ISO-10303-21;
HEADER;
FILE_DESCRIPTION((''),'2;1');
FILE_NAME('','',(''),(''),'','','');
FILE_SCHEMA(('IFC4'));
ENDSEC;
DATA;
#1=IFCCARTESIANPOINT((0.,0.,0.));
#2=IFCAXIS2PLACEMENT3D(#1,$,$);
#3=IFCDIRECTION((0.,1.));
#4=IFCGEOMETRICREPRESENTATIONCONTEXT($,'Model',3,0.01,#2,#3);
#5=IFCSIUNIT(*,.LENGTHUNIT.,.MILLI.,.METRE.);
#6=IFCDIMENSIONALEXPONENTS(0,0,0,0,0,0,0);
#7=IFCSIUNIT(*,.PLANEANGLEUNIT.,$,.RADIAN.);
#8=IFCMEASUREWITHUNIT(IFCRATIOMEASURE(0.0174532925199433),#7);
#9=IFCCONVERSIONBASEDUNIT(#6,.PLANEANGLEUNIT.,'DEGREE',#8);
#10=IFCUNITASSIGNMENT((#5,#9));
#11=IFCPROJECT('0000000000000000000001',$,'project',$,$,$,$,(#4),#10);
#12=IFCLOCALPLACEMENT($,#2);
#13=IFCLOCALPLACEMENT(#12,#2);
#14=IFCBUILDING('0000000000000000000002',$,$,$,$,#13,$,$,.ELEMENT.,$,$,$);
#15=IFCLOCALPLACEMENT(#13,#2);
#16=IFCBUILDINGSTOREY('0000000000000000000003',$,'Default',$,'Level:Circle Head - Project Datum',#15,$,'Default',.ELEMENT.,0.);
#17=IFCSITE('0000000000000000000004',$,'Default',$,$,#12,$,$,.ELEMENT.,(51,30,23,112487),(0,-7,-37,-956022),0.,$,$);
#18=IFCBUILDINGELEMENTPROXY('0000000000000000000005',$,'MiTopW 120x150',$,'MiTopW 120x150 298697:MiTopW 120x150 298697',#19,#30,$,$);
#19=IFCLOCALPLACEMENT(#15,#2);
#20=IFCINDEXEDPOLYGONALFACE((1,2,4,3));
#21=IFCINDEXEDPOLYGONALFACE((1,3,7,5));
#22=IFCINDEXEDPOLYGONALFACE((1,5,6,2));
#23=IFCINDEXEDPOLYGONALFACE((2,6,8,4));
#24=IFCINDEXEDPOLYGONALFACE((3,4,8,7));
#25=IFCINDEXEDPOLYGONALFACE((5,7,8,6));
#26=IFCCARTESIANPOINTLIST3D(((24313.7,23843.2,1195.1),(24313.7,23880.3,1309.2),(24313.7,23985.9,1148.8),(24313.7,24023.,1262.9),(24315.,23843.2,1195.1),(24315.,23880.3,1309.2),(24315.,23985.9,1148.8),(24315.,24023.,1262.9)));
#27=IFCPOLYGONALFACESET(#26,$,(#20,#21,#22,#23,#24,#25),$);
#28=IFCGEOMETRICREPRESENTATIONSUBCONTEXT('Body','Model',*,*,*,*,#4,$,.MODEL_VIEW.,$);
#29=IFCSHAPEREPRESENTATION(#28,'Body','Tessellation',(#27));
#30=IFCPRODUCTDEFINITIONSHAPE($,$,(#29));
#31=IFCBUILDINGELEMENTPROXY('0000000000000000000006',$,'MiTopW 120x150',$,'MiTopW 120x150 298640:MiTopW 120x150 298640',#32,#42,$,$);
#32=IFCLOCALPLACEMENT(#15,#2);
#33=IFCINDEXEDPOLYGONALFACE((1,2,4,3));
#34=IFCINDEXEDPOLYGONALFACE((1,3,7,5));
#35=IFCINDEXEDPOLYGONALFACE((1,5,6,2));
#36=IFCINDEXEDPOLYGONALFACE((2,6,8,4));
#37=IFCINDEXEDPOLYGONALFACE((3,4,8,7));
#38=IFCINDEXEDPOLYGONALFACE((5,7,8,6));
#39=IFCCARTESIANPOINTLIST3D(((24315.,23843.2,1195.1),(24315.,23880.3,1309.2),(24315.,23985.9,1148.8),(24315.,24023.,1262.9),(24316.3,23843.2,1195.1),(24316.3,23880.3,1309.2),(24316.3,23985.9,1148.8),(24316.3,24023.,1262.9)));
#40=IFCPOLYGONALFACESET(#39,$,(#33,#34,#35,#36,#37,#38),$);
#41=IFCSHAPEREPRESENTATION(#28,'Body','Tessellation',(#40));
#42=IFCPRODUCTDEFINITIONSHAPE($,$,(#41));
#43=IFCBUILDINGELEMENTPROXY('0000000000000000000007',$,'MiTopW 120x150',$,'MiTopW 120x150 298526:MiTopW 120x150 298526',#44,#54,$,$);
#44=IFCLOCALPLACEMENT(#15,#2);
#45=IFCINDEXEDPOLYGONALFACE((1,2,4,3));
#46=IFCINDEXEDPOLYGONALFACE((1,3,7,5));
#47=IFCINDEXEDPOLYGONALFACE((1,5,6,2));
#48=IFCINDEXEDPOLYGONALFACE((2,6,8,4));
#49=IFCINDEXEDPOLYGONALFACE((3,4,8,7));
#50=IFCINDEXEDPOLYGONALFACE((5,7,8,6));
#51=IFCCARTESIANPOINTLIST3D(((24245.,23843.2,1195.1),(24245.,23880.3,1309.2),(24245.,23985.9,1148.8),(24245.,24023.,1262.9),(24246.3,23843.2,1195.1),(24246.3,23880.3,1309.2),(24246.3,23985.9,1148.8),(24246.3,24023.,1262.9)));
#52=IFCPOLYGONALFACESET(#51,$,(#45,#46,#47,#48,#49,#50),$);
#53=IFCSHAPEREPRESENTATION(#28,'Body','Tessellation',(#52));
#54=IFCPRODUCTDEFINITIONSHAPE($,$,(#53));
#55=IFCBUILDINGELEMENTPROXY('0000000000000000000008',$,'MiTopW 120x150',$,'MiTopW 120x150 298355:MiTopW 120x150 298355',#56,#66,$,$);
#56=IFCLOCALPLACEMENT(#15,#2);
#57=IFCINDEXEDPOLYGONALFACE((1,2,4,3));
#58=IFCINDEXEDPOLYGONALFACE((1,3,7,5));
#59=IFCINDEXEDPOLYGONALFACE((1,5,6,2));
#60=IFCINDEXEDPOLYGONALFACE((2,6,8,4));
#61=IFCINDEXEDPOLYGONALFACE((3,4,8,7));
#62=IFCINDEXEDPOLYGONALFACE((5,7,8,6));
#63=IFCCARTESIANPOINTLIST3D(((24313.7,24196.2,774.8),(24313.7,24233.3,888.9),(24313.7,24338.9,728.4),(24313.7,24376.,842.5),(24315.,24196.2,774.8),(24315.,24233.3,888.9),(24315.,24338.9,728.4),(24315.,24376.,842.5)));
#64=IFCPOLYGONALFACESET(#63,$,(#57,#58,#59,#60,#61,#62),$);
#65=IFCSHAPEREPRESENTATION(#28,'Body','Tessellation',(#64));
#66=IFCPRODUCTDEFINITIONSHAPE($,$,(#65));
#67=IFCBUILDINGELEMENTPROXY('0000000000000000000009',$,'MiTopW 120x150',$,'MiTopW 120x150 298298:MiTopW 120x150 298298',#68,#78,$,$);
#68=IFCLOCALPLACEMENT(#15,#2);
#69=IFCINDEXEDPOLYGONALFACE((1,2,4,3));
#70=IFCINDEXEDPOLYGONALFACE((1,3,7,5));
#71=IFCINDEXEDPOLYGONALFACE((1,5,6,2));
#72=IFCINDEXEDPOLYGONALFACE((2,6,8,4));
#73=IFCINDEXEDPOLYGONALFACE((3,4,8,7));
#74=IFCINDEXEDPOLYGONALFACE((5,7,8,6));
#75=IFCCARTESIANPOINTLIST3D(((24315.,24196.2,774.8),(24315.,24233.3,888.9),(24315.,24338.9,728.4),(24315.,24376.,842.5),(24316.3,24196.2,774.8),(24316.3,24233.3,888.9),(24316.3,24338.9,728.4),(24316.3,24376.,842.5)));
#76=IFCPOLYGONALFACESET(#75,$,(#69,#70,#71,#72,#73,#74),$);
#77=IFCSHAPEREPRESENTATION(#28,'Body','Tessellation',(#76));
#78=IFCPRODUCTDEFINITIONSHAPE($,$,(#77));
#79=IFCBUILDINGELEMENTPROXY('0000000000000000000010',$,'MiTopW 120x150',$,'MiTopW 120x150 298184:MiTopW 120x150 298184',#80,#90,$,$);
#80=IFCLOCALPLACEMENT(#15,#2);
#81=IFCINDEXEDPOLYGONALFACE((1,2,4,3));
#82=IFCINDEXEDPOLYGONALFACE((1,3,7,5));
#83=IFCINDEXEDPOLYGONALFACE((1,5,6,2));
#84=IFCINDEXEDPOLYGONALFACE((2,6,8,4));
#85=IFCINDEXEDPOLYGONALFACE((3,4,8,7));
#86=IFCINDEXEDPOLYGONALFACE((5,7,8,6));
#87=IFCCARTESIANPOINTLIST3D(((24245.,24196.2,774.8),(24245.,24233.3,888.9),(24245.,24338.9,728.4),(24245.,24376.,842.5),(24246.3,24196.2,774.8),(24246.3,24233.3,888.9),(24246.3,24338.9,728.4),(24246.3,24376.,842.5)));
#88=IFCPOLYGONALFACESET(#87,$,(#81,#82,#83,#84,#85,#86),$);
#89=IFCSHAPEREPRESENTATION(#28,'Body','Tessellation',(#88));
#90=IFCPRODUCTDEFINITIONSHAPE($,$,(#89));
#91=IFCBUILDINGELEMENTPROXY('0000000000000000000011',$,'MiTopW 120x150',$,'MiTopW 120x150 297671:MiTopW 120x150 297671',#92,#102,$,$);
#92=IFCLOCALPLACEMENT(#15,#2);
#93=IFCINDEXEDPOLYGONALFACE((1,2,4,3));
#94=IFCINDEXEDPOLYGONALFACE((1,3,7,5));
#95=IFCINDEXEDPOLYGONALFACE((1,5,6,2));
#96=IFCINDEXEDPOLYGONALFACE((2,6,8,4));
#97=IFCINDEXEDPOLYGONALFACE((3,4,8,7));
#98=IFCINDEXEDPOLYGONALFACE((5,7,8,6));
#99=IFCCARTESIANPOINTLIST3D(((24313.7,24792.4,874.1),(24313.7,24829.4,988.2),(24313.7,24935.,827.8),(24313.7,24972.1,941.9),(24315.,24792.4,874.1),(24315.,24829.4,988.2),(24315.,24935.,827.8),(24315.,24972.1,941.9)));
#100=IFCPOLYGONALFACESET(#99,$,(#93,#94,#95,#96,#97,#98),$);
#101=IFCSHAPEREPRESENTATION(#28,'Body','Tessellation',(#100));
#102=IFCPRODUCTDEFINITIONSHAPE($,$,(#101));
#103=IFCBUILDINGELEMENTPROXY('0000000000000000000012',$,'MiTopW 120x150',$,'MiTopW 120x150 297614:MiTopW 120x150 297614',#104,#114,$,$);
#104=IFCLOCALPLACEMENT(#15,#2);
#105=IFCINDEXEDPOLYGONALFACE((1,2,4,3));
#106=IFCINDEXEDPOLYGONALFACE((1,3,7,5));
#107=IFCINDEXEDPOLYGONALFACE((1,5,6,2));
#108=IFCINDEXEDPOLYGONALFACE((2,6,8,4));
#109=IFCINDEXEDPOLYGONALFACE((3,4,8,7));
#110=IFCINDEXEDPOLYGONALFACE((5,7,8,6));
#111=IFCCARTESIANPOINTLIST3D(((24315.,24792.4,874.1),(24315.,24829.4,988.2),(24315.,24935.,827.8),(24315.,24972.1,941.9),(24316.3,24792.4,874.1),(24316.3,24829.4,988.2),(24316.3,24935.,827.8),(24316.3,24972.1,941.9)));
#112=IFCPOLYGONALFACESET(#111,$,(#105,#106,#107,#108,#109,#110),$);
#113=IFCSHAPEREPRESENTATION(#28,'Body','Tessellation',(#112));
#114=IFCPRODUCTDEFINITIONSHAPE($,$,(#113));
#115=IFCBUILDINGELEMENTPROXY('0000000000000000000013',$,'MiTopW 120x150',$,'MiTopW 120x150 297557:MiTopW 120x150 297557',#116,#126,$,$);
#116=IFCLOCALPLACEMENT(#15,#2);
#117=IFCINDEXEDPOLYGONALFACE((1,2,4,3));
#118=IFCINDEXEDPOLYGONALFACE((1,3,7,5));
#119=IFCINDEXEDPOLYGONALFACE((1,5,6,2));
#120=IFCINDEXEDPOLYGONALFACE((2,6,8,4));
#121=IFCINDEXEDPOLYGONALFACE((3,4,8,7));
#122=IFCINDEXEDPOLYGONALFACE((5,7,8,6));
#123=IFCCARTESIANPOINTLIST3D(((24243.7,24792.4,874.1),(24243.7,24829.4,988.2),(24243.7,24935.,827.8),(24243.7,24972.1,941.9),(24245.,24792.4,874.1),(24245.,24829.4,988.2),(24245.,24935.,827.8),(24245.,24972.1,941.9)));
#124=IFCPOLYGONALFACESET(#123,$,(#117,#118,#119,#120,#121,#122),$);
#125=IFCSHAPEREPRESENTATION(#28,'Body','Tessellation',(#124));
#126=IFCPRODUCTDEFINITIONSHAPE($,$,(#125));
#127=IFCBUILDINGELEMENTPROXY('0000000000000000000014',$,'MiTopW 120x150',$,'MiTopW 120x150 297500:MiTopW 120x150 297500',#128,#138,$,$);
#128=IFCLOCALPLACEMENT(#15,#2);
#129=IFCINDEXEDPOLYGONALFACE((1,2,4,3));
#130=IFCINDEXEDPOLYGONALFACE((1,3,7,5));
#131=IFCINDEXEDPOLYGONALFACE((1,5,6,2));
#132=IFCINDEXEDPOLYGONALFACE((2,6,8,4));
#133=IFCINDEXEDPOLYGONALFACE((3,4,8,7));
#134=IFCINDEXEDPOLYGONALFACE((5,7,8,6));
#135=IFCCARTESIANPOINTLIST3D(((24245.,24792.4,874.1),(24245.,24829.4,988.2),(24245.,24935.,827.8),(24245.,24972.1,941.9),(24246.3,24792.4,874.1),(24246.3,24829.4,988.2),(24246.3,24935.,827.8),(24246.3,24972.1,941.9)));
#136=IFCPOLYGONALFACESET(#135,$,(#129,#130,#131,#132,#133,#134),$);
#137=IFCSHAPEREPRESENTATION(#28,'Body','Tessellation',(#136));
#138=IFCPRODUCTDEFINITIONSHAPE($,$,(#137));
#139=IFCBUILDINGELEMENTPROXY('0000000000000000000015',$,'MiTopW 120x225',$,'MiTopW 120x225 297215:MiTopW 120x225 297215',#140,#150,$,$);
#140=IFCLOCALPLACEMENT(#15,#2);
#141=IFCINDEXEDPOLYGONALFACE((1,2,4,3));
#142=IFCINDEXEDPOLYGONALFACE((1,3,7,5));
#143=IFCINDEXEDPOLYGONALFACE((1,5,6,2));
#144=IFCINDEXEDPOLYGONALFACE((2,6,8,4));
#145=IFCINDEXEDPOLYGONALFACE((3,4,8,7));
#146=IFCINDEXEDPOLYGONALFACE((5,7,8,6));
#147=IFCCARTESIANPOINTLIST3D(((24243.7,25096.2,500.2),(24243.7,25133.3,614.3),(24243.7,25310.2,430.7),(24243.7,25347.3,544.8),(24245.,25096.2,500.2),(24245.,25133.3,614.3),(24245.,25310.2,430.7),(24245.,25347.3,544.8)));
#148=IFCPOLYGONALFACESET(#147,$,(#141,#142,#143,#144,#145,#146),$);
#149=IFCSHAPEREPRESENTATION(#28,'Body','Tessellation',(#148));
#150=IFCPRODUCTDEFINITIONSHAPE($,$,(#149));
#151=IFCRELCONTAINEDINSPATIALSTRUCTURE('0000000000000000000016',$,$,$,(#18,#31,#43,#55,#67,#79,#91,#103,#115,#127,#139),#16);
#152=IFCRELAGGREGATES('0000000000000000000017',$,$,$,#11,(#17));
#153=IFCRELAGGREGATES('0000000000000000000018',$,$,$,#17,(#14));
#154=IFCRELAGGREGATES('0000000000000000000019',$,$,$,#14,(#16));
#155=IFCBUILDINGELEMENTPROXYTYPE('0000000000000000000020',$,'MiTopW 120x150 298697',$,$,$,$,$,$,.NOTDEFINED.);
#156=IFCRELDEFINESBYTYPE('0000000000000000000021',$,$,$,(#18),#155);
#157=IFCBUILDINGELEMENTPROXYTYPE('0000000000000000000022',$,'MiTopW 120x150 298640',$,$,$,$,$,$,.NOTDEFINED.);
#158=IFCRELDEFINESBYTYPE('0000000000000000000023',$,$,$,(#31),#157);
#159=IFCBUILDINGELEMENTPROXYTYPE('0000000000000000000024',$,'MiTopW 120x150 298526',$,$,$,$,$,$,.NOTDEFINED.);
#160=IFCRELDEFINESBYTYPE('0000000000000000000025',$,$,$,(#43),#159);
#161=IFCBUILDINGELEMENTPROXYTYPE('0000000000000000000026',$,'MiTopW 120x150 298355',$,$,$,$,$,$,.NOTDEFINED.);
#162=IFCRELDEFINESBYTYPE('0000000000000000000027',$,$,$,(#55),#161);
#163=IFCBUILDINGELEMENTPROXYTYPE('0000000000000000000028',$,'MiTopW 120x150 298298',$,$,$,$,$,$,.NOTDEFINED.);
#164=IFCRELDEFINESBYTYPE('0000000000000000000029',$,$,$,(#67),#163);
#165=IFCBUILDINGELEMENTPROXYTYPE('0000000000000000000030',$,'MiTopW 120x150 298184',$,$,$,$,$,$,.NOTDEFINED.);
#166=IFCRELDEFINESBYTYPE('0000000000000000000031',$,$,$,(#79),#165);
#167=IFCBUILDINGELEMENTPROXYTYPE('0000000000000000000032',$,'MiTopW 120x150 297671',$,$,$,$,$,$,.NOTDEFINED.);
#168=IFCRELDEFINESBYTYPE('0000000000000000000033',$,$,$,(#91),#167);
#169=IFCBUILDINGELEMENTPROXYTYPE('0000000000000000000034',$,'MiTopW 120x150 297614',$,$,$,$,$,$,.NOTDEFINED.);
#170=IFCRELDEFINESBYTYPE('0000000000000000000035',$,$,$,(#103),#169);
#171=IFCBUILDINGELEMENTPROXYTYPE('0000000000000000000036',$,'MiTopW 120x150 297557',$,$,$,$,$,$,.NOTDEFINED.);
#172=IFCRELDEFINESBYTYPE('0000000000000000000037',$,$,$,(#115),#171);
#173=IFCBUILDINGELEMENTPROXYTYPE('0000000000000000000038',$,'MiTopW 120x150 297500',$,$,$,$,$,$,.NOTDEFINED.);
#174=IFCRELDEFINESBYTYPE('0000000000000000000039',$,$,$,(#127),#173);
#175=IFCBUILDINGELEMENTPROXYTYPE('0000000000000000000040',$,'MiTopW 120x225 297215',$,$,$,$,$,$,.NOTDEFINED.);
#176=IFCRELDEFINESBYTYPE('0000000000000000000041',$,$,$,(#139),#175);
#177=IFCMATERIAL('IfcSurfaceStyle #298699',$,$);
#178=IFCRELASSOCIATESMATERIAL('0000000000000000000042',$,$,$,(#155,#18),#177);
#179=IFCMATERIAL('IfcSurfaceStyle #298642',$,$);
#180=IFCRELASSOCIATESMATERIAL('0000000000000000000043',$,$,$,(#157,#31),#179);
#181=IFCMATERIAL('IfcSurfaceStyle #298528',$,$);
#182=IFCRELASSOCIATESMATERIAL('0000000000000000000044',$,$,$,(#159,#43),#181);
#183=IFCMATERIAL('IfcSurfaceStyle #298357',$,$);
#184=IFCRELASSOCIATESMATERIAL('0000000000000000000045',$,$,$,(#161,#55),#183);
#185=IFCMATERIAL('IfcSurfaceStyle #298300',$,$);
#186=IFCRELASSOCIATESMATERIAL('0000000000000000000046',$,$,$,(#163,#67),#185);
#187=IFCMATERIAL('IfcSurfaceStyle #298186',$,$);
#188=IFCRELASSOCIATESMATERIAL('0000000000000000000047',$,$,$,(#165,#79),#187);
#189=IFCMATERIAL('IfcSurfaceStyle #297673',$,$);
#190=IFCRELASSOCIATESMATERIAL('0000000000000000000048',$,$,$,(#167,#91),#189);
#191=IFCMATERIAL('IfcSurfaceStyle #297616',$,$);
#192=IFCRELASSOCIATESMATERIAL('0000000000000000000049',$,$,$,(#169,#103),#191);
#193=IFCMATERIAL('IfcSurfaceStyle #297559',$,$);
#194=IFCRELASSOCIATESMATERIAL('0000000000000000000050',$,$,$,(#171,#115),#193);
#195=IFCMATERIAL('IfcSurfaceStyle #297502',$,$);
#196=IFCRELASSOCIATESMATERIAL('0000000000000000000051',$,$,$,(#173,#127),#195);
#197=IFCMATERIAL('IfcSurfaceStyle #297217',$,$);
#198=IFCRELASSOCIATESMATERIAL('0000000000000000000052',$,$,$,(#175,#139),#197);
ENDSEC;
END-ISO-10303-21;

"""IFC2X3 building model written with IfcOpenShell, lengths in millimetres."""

from ifc_helpers import new_model, entity, si_unit, converted_unit, direction, frame, origin, place, context, subcontext, project, spatial, polyline, outline, extrude, source, transform, mapped, material, type_object, type_shapes, element, save


model = new_model("IFC2X3")

# Units and contexts
model_context = context("Model", 3, precision=0.01, world=origin(), true_north=direction((0.0, 1.0)))
body_context = subcontext(model_context, "Body", "Model", "MODEL_VIEW")
ifc_project = project(units=[si_unit("LENGTHUNIT", "METRE", prefix="MILLI"), converted_unit("PLANEANGLEUNIT", "DEGREE", entity("IfcRatioMeasure", 0.0174532925199433), si_unit("PLANEANGLEUNIT", "RADIAN"), dimensions=[0, 0, 0, 0, 0, 0, 0])], contexts=[model_context])

# Site, building, storey
site_placement = place(None, origin())
site = spatial("IfcSite", under=ifc_project, at=site_placement, Name="Default", CompositionType="ELEMENT", RefLatitude=(51, 30, 23, 112487), RefLongitude=(0, -7, -37, -956022), RefElevation=0.0)
building_placement = place(site_placement, origin())
building = spatial("IfcBuilding", under=site, at=building_placement, CompositionType="ELEMENT")
storey_placement = place(building_placement, origin())
storey = spatial("IfcBuildingStorey", under=building, at=storey_placement, Name="Default", ObjectType="Level:Circle Head - Project Datum", LongName="Default", CompositionType="ELEMENT", Elevation=0.0)

# Building element proxies
ifc_material_1 = material(Name="IfcSurfaceStyle #298699")
building_element_proxy_type_1 = type_object("IfcBuildingElementProxyType", Name="MiTopW 120x150 298697", PredefinedType="NOTDEFINED", material=ifc_material_1)
shared_shape_1 = source(origin(), body_context, "Body", "SweptSolid", [
    extrude(outline(polyline([(-75.0, -60.0), (75.0, -60.0), (75.0, 60.0), (-75.0, 60.0), (-75.0, -60.0)])), frame((75.0, 60.0, 0.0), z_axis=(0.0, 0.0, 1.0), x_axis=(-1.0, 0.0, 0.0)), (0.0, 0.0, 1.0), 1.3),
])
type_shapes(building_element_proxy_type_1, [shared_shape_1])
proxy_1_placement = place(building_placement, frame((24315.0, 23985.9, 1148.8), z_axis=(-1.0, 0.0, 0.0), x_axis=(0.0, -0.951057, 0.309017)))
element("IfcBuildingElementProxy", 1, at=proxy_1_placement, inside=storey, type_object=building_element_proxy_type_1, material=ifc_material_1, Name="MiTopW 120x150", ObjectType="MiTopW 120x150 298697:MiTopW 120x150 298697", context=body_context, shape_type="MappedRepresentation", body=[
    mapped(shared_shape_1, transform((0.0, 0.0, 0.0), scale=1.0)),
])
ifc_material_2 = material(Name="IfcSurfaceStyle #298642")
building_element_proxy_type_2 = type_object("IfcBuildingElementProxyType", Name="MiTopW 120x150 298640", PredefinedType="NOTDEFINED", material=ifc_material_2)
shared_shape_2 = source(origin(), body_context, "Body", "SweptSolid", [
    extrude(outline(polyline([(-75.0, -60.0), (75.0, -60.0), (75.0, 60.0), (-75.0, 60.0), (-75.0, -60.0)])), frame((75.0, 60.0, 0.0), z_axis=(0.0, 0.0, 1.0), x_axis=(-1.0, 0.0, 0.0)), (0.0, 0.0, 1.0), 1.3),
])
type_shapes(building_element_proxy_type_2, [shared_shape_2])
proxy_2_placement = place(building_placement, frame((24316.3, 23985.9, 1148.8), z_axis=(-1.0, 0.0, 0.0), x_axis=(0.0, -0.951057, 0.309017)))
element("IfcBuildingElementProxy", 2, at=proxy_2_placement, inside=storey, type_object=building_element_proxy_type_2, material=ifc_material_2, Name="MiTopW 120x150", ObjectType="MiTopW 120x150 298640:MiTopW 120x150 298640", context=body_context, shape_type="MappedRepresentation", body=[
    mapped(shared_shape_2, transform((0.0, 0.0, 0.0), scale=1.0)),
])
ifc_material_3 = material(Name="IfcSurfaceStyle #298528")
building_element_proxy_type_3 = type_object("IfcBuildingElementProxyType", Name="MiTopW 120x150 298526", PredefinedType="NOTDEFINED", material=ifc_material_3)
shared_shape_3 = source(origin(), body_context, "Body", "SweptSolid", [
    extrude(outline(polyline([(-75.0, -60.0), (75.0, -60.0), (75.0, 60.0), (-75.0, 60.0), (-75.0, -60.0)])), frame((75.0, 60.0, 0.0), z_axis=(0.0, 0.0, 1.0), x_axis=(-1.0, 0.0, 0.0)), (0.0, 0.0, 1.0), 1.3),
])
type_shapes(building_element_proxy_type_3, [shared_shape_3])
proxy_3_placement = place(building_placement, frame((24246.3, 23985.9, 1148.8), z_axis=(-1.0, 0.0, 0.0), x_axis=(0.0, -0.951057, 0.309017)))
element("IfcBuildingElementProxy", 3, at=proxy_3_placement, inside=storey, type_object=building_element_proxy_type_3, material=ifc_material_3, Name="MiTopW 120x150", ObjectType="MiTopW 120x150 298526:MiTopW 120x150 298526", context=body_context, shape_type="MappedRepresentation", body=[
    mapped(shared_shape_3, transform((0.0, 0.0, 0.0), scale=1.0)),
])
ifc_material_4 = material(Name="IfcSurfaceStyle #298357")
building_element_proxy_type_4 = type_object("IfcBuildingElementProxyType", Name="MiTopW 120x150 298355", PredefinedType="NOTDEFINED", material=ifc_material_4)
shared_shape_4 = source(origin(), body_context, "Body", "SweptSolid", [
    extrude(outline(polyline([(-75.0, -60.0), (75.0, -60.0), (75.0, 60.0), (-75.0, 60.0), (-75.0, -60.0)])), frame((75.0, 60.0, 0.0), z_axis=(0.0, 0.0, 1.0), x_axis=(-1.0, 0.0, 0.0)), (0.0, 0.0, 1.0), 1.3),
])
type_shapes(building_element_proxy_type_4, [shared_shape_4])
proxy_4_placement = place(building_placement, frame((24315.0, 24338.9, 728.4), z_axis=(-1.0, 0.0, 0.0), x_axis=(0.0, -0.951057, 0.309017)))
element("IfcBuildingElementProxy", 4, at=proxy_4_placement, inside=storey, type_object=building_element_proxy_type_4, material=ifc_material_4, Name="MiTopW 120x150", ObjectType="MiTopW 120x150 298355:MiTopW 120x150 298355", context=body_context, shape_type="MappedRepresentation", body=[
    mapped(shared_shape_4, transform((0.0, 0.0, 0.0), scale=1.0)),
])
ifc_material_5 = material(Name="IfcSurfaceStyle #298300")
building_element_proxy_type_5 = type_object("IfcBuildingElementProxyType", Name="MiTopW 120x150 298298", PredefinedType="NOTDEFINED", material=ifc_material_5)
shared_shape_5 = source(origin(), body_context, "Body", "SweptSolid", [
    extrude(outline(polyline([(-75.0, -60.0), (75.0, -60.0), (75.0, 60.0), (-75.0, 60.0), (-75.0, -60.0)])), frame((75.0, 60.0, 0.0), z_axis=(0.0, 0.0, 1.0), x_axis=(-1.0, 0.0, 0.0)), (0.0, 0.0, 1.0), 1.3),
])
type_shapes(building_element_proxy_type_5, [shared_shape_5])
proxy_5_placement = place(building_placement, frame((24316.3, 24338.9, 728.4), z_axis=(-1.0, 0.0, 0.0), x_axis=(0.0, -0.951057, 0.309017)))
element("IfcBuildingElementProxy", 5, at=proxy_5_placement, inside=storey, type_object=building_element_proxy_type_5, material=ifc_material_5, Name="MiTopW 120x150", ObjectType="MiTopW 120x150 298298:MiTopW 120x150 298298", context=body_context, shape_type="MappedRepresentation", body=[
    mapped(shared_shape_5, transform((0.0, 0.0, 0.0), scale=1.0)),
])
ifc_material_6 = material(Name="IfcSurfaceStyle #298186")
building_element_proxy_type_6 = type_object("IfcBuildingElementProxyType", Name="MiTopW 120x150 298184", PredefinedType="NOTDEFINED", material=ifc_material_6)
shared_shape_6 = source(origin(), body_context, "Body", "SweptSolid", [
    extrude(outline(polyline([(-75.0, -60.0), (75.0, -60.0), (75.0, 60.0), (-75.0, 60.0), (-75.0, -60.0)])), frame((75.0, 60.0, 0.0), z_axis=(0.0, 0.0, 1.0), x_axis=(-1.0, 0.0, 0.0)), (0.0, 0.0, 1.0), 1.3),
])
type_shapes(building_element_proxy_type_6, [shared_shape_6])
proxy_6_placement = place(building_placement, frame((24246.3, 24338.9, 728.4), z_axis=(-1.0, 0.0, 0.0), x_axis=(0.0, -0.951057, 0.309017)))
element("IfcBuildingElementProxy", 6, at=proxy_6_placement, inside=storey, type_object=building_element_proxy_type_6, material=ifc_material_6, Name="MiTopW 120x150", ObjectType="MiTopW 120x150 298184:MiTopW 120x150 298184", context=body_context, shape_type="MappedRepresentation", body=[
    mapped(shared_shape_6, transform((0.0, 0.0, 0.0), scale=1.0)),
])
ifc_material_7 = material(Name="IfcSurfaceStyle #297673")
building_element_proxy_type_7 = type_object("IfcBuildingElementProxyType", Name="MiTopW 120x150 297671", PredefinedType="NOTDEFINED", material=ifc_material_7)
shared_shape_7 = source(origin(), body_context, "Body", "SweptSolid", [
    extrude(outline(polyline([(-75.0, -60.0), (75.0, -60.0), (75.0, 60.0), (-75.0, 60.0), (-75.0, -60.0)])), frame((75.0, 60.0, 0.0), z_axis=(0.0, 0.0, 1.0), x_axis=(-1.0, 0.0, 0.0)), (0.0, 0.0, 1.0), 1.3),
])
type_shapes(building_element_proxy_type_7, [shared_shape_7])
proxy_7_placement = place(building_placement, frame((24315.0, 24935.0, 827.8), z_axis=(-1.0, 0.0, 0.0), x_axis=(0.0, -0.951057, 0.309017)))
element("IfcBuildingElementProxy", 7, at=proxy_7_placement, inside=storey, type_object=building_element_proxy_type_7, material=ifc_material_7, Name="MiTopW 120x150", ObjectType="MiTopW 120x150 297671:MiTopW 120x150 297671", context=body_context, shape_type="MappedRepresentation", body=[
    mapped(shared_shape_7, transform((0.0, 0.0, 0.0), scale=1.0)),
])
ifc_material_8 = material(Name="IfcSurfaceStyle #297616")
building_element_proxy_type_8 = type_object("IfcBuildingElementProxyType", Name="MiTopW 120x150 297614", PredefinedType="NOTDEFINED", material=ifc_material_8)
shared_shape_8 = source(origin(), body_context, "Body", "SweptSolid", [
    extrude(outline(polyline([(-75.0, -60.0), (75.0, -60.0), (75.0, 60.0), (-75.0, 60.0), (-75.0, -60.0)])), frame((75.0, 60.0, 0.0), z_axis=(0.0, 0.0, 1.0), x_axis=(-1.0, 0.0, 0.0)), (0.0, 0.0, 1.0), 1.3),
])
type_shapes(building_element_proxy_type_8, [shared_shape_8])
proxy_8_placement = place(building_placement, frame((24316.3, 24935.0, 827.8), z_axis=(-1.0, 0.0, 0.0), x_axis=(0.0, -0.951057, 0.309017)))
element("IfcBuildingElementProxy", 8, at=proxy_8_placement, inside=storey, type_object=building_element_proxy_type_8, material=ifc_material_8, Name="MiTopW 120x150", ObjectType="MiTopW 120x150 297614:MiTopW 120x150 297614", context=body_context, shape_type="MappedRepresentation", body=[
    mapped(shared_shape_8, transform((0.0, 0.0, 0.0), scale=1.0)),
])
ifc_material_9 = material(Name="IfcSurfaceStyle #297559")
building_element_proxy_type_9 = type_object("IfcBuildingElementProxyType", Name="MiTopW 120x150 297557", PredefinedType="NOTDEFINED", material=ifc_material_9)
shared_shape_9 = source(origin(), body_context, "Body", "SweptSolid", [
    extrude(outline(polyline([(-75.0, -60.0), (75.0, -60.0), (75.0, 60.0), (-75.0, 60.0), (-75.0, -60.0)])), frame((75.0, 60.0, 0.0), z_axis=(0.0, 0.0, 1.0), x_axis=(-1.0, 0.0, 0.0)), (0.0, 0.0, 1.0), 1.3),
])
type_shapes(building_element_proxy_type_9, [shared_shape_9])
proxy_9_placement = place(building_placement, frame((24245.0, 24935.0, 827.8), z_axis=(-1.0, 0.0, 0.0), x_axis=(0.0, -0.951057, 0.309017)))
element("IfcBuildingElementProxy", 9, at=proxy_9_placement, inside=storey, type_object=building_element_proxy_type_9, material=ifc_material_9, Name="MiTopW 120x150", ObjectType="MiTopW 120x150 297557:MiTopW 120x150 297557", context=body_context, shape_type="MappedRepresentation", body=[
    mapped(shared_shape_9, transform((0.0, 0.0, 0.0), scale=1.0)),
])
ifc_material_10 = material(Name="IfcSurfaceStyle #297502")
building_element_proxy_type_10 = type_object("IfcBuildingElementProxyType", Name="MiTopW 120x150 297500", PredefinedType="NOTDEFINED", material=ifc_material_10)
shared_shape_10 = source(origin(), body_context, "Body", "SweptSolid", [
    extrude(outline(polyline([(-75.0, -60.0), (75.0, -60.0), (75.0, 60.0), (-75.0, 60.0), (-75.0, -60.0)])), frame((75.0, 60.0, 0.0), z_axis=(0.0, 0.0, 1.0), x_axis=(-1.0, 0.0, 0.0)), (0.0, 0.0, 1.0), 1.3),
])
type_shapes(building_element_proxy_type_10, [shared_shape_10])
proxy_10_placement = place(building_placement, frame((24246.3, 24935.0, 827.8), z_axis=(-1.0, 0.0, 0.0), x_axis=(0.0, -0.951057, 0.309017)))
element("IfcBuildingElementProxy", 10, at=proxy_10_placement, inside=storey, type_object=building_element_proxy_type_10, material=ifc_material_10, Name="MiTopW 120x150", ObjectType="MiTopW 120x150 297500:MiTopW 120x150 297500", context=body_context, shape_type="MappedRepresentation", body=[
    mapped(shared_shape_10, transform((0.0, 0.0, 0.0), scale=1.0)),
])
ifc_material_11 = material(Name="IfcSurfaceStyle #297217")
building_element_proxy_type_11 = type_object("IfcBuildingElementProxyType", Name="MiTopW 120x225 297215", PredefinedType="NOTDEFINED", material=ifc_material_11)
shared_shape_11 = source(origin(), body_context, "Body", "SweptSolid", [
    extrude(outline(polyline([(-112.5, -60.0), (112.5, -60.0), (112.5, 60.0), (-112.5, 60.0), (-112.5, -60.0)])), frame((112.5, 60.0, 0.0), z_axis=(0.0, 0.0, 1.0), x_axis=(-1.0, 0.0, 0.0)), (0.0, 0.0, 1.0), 1.3),
])
type_shapes(building_element_proxy_type_11, [shared_shape_11])
proxy_11_placement = place(building_placement, frame((24245.0, 25310.2, 430.7), z_axis=(-1.0, 0.0, 0.0), x_axis=(0.0, -0.951057, 0.309017)))
element("IfcBuildingElementProxy", 11, at=proxy_11_placement, inside=storey, type_object=building_element_proxy_type_11, material=ifc_material_11, Name="MiTopW 120x225", ObjectType="MiTopW 120x225 297215:MiTopW 120x225 297215", context=body_context, shape_type="MappedRepresentation", body=[
    mapped(shared_shape_11, transform((0.0, 0.0, 0.0), scale=1.0)),
])

save(model, "model.ifc")
